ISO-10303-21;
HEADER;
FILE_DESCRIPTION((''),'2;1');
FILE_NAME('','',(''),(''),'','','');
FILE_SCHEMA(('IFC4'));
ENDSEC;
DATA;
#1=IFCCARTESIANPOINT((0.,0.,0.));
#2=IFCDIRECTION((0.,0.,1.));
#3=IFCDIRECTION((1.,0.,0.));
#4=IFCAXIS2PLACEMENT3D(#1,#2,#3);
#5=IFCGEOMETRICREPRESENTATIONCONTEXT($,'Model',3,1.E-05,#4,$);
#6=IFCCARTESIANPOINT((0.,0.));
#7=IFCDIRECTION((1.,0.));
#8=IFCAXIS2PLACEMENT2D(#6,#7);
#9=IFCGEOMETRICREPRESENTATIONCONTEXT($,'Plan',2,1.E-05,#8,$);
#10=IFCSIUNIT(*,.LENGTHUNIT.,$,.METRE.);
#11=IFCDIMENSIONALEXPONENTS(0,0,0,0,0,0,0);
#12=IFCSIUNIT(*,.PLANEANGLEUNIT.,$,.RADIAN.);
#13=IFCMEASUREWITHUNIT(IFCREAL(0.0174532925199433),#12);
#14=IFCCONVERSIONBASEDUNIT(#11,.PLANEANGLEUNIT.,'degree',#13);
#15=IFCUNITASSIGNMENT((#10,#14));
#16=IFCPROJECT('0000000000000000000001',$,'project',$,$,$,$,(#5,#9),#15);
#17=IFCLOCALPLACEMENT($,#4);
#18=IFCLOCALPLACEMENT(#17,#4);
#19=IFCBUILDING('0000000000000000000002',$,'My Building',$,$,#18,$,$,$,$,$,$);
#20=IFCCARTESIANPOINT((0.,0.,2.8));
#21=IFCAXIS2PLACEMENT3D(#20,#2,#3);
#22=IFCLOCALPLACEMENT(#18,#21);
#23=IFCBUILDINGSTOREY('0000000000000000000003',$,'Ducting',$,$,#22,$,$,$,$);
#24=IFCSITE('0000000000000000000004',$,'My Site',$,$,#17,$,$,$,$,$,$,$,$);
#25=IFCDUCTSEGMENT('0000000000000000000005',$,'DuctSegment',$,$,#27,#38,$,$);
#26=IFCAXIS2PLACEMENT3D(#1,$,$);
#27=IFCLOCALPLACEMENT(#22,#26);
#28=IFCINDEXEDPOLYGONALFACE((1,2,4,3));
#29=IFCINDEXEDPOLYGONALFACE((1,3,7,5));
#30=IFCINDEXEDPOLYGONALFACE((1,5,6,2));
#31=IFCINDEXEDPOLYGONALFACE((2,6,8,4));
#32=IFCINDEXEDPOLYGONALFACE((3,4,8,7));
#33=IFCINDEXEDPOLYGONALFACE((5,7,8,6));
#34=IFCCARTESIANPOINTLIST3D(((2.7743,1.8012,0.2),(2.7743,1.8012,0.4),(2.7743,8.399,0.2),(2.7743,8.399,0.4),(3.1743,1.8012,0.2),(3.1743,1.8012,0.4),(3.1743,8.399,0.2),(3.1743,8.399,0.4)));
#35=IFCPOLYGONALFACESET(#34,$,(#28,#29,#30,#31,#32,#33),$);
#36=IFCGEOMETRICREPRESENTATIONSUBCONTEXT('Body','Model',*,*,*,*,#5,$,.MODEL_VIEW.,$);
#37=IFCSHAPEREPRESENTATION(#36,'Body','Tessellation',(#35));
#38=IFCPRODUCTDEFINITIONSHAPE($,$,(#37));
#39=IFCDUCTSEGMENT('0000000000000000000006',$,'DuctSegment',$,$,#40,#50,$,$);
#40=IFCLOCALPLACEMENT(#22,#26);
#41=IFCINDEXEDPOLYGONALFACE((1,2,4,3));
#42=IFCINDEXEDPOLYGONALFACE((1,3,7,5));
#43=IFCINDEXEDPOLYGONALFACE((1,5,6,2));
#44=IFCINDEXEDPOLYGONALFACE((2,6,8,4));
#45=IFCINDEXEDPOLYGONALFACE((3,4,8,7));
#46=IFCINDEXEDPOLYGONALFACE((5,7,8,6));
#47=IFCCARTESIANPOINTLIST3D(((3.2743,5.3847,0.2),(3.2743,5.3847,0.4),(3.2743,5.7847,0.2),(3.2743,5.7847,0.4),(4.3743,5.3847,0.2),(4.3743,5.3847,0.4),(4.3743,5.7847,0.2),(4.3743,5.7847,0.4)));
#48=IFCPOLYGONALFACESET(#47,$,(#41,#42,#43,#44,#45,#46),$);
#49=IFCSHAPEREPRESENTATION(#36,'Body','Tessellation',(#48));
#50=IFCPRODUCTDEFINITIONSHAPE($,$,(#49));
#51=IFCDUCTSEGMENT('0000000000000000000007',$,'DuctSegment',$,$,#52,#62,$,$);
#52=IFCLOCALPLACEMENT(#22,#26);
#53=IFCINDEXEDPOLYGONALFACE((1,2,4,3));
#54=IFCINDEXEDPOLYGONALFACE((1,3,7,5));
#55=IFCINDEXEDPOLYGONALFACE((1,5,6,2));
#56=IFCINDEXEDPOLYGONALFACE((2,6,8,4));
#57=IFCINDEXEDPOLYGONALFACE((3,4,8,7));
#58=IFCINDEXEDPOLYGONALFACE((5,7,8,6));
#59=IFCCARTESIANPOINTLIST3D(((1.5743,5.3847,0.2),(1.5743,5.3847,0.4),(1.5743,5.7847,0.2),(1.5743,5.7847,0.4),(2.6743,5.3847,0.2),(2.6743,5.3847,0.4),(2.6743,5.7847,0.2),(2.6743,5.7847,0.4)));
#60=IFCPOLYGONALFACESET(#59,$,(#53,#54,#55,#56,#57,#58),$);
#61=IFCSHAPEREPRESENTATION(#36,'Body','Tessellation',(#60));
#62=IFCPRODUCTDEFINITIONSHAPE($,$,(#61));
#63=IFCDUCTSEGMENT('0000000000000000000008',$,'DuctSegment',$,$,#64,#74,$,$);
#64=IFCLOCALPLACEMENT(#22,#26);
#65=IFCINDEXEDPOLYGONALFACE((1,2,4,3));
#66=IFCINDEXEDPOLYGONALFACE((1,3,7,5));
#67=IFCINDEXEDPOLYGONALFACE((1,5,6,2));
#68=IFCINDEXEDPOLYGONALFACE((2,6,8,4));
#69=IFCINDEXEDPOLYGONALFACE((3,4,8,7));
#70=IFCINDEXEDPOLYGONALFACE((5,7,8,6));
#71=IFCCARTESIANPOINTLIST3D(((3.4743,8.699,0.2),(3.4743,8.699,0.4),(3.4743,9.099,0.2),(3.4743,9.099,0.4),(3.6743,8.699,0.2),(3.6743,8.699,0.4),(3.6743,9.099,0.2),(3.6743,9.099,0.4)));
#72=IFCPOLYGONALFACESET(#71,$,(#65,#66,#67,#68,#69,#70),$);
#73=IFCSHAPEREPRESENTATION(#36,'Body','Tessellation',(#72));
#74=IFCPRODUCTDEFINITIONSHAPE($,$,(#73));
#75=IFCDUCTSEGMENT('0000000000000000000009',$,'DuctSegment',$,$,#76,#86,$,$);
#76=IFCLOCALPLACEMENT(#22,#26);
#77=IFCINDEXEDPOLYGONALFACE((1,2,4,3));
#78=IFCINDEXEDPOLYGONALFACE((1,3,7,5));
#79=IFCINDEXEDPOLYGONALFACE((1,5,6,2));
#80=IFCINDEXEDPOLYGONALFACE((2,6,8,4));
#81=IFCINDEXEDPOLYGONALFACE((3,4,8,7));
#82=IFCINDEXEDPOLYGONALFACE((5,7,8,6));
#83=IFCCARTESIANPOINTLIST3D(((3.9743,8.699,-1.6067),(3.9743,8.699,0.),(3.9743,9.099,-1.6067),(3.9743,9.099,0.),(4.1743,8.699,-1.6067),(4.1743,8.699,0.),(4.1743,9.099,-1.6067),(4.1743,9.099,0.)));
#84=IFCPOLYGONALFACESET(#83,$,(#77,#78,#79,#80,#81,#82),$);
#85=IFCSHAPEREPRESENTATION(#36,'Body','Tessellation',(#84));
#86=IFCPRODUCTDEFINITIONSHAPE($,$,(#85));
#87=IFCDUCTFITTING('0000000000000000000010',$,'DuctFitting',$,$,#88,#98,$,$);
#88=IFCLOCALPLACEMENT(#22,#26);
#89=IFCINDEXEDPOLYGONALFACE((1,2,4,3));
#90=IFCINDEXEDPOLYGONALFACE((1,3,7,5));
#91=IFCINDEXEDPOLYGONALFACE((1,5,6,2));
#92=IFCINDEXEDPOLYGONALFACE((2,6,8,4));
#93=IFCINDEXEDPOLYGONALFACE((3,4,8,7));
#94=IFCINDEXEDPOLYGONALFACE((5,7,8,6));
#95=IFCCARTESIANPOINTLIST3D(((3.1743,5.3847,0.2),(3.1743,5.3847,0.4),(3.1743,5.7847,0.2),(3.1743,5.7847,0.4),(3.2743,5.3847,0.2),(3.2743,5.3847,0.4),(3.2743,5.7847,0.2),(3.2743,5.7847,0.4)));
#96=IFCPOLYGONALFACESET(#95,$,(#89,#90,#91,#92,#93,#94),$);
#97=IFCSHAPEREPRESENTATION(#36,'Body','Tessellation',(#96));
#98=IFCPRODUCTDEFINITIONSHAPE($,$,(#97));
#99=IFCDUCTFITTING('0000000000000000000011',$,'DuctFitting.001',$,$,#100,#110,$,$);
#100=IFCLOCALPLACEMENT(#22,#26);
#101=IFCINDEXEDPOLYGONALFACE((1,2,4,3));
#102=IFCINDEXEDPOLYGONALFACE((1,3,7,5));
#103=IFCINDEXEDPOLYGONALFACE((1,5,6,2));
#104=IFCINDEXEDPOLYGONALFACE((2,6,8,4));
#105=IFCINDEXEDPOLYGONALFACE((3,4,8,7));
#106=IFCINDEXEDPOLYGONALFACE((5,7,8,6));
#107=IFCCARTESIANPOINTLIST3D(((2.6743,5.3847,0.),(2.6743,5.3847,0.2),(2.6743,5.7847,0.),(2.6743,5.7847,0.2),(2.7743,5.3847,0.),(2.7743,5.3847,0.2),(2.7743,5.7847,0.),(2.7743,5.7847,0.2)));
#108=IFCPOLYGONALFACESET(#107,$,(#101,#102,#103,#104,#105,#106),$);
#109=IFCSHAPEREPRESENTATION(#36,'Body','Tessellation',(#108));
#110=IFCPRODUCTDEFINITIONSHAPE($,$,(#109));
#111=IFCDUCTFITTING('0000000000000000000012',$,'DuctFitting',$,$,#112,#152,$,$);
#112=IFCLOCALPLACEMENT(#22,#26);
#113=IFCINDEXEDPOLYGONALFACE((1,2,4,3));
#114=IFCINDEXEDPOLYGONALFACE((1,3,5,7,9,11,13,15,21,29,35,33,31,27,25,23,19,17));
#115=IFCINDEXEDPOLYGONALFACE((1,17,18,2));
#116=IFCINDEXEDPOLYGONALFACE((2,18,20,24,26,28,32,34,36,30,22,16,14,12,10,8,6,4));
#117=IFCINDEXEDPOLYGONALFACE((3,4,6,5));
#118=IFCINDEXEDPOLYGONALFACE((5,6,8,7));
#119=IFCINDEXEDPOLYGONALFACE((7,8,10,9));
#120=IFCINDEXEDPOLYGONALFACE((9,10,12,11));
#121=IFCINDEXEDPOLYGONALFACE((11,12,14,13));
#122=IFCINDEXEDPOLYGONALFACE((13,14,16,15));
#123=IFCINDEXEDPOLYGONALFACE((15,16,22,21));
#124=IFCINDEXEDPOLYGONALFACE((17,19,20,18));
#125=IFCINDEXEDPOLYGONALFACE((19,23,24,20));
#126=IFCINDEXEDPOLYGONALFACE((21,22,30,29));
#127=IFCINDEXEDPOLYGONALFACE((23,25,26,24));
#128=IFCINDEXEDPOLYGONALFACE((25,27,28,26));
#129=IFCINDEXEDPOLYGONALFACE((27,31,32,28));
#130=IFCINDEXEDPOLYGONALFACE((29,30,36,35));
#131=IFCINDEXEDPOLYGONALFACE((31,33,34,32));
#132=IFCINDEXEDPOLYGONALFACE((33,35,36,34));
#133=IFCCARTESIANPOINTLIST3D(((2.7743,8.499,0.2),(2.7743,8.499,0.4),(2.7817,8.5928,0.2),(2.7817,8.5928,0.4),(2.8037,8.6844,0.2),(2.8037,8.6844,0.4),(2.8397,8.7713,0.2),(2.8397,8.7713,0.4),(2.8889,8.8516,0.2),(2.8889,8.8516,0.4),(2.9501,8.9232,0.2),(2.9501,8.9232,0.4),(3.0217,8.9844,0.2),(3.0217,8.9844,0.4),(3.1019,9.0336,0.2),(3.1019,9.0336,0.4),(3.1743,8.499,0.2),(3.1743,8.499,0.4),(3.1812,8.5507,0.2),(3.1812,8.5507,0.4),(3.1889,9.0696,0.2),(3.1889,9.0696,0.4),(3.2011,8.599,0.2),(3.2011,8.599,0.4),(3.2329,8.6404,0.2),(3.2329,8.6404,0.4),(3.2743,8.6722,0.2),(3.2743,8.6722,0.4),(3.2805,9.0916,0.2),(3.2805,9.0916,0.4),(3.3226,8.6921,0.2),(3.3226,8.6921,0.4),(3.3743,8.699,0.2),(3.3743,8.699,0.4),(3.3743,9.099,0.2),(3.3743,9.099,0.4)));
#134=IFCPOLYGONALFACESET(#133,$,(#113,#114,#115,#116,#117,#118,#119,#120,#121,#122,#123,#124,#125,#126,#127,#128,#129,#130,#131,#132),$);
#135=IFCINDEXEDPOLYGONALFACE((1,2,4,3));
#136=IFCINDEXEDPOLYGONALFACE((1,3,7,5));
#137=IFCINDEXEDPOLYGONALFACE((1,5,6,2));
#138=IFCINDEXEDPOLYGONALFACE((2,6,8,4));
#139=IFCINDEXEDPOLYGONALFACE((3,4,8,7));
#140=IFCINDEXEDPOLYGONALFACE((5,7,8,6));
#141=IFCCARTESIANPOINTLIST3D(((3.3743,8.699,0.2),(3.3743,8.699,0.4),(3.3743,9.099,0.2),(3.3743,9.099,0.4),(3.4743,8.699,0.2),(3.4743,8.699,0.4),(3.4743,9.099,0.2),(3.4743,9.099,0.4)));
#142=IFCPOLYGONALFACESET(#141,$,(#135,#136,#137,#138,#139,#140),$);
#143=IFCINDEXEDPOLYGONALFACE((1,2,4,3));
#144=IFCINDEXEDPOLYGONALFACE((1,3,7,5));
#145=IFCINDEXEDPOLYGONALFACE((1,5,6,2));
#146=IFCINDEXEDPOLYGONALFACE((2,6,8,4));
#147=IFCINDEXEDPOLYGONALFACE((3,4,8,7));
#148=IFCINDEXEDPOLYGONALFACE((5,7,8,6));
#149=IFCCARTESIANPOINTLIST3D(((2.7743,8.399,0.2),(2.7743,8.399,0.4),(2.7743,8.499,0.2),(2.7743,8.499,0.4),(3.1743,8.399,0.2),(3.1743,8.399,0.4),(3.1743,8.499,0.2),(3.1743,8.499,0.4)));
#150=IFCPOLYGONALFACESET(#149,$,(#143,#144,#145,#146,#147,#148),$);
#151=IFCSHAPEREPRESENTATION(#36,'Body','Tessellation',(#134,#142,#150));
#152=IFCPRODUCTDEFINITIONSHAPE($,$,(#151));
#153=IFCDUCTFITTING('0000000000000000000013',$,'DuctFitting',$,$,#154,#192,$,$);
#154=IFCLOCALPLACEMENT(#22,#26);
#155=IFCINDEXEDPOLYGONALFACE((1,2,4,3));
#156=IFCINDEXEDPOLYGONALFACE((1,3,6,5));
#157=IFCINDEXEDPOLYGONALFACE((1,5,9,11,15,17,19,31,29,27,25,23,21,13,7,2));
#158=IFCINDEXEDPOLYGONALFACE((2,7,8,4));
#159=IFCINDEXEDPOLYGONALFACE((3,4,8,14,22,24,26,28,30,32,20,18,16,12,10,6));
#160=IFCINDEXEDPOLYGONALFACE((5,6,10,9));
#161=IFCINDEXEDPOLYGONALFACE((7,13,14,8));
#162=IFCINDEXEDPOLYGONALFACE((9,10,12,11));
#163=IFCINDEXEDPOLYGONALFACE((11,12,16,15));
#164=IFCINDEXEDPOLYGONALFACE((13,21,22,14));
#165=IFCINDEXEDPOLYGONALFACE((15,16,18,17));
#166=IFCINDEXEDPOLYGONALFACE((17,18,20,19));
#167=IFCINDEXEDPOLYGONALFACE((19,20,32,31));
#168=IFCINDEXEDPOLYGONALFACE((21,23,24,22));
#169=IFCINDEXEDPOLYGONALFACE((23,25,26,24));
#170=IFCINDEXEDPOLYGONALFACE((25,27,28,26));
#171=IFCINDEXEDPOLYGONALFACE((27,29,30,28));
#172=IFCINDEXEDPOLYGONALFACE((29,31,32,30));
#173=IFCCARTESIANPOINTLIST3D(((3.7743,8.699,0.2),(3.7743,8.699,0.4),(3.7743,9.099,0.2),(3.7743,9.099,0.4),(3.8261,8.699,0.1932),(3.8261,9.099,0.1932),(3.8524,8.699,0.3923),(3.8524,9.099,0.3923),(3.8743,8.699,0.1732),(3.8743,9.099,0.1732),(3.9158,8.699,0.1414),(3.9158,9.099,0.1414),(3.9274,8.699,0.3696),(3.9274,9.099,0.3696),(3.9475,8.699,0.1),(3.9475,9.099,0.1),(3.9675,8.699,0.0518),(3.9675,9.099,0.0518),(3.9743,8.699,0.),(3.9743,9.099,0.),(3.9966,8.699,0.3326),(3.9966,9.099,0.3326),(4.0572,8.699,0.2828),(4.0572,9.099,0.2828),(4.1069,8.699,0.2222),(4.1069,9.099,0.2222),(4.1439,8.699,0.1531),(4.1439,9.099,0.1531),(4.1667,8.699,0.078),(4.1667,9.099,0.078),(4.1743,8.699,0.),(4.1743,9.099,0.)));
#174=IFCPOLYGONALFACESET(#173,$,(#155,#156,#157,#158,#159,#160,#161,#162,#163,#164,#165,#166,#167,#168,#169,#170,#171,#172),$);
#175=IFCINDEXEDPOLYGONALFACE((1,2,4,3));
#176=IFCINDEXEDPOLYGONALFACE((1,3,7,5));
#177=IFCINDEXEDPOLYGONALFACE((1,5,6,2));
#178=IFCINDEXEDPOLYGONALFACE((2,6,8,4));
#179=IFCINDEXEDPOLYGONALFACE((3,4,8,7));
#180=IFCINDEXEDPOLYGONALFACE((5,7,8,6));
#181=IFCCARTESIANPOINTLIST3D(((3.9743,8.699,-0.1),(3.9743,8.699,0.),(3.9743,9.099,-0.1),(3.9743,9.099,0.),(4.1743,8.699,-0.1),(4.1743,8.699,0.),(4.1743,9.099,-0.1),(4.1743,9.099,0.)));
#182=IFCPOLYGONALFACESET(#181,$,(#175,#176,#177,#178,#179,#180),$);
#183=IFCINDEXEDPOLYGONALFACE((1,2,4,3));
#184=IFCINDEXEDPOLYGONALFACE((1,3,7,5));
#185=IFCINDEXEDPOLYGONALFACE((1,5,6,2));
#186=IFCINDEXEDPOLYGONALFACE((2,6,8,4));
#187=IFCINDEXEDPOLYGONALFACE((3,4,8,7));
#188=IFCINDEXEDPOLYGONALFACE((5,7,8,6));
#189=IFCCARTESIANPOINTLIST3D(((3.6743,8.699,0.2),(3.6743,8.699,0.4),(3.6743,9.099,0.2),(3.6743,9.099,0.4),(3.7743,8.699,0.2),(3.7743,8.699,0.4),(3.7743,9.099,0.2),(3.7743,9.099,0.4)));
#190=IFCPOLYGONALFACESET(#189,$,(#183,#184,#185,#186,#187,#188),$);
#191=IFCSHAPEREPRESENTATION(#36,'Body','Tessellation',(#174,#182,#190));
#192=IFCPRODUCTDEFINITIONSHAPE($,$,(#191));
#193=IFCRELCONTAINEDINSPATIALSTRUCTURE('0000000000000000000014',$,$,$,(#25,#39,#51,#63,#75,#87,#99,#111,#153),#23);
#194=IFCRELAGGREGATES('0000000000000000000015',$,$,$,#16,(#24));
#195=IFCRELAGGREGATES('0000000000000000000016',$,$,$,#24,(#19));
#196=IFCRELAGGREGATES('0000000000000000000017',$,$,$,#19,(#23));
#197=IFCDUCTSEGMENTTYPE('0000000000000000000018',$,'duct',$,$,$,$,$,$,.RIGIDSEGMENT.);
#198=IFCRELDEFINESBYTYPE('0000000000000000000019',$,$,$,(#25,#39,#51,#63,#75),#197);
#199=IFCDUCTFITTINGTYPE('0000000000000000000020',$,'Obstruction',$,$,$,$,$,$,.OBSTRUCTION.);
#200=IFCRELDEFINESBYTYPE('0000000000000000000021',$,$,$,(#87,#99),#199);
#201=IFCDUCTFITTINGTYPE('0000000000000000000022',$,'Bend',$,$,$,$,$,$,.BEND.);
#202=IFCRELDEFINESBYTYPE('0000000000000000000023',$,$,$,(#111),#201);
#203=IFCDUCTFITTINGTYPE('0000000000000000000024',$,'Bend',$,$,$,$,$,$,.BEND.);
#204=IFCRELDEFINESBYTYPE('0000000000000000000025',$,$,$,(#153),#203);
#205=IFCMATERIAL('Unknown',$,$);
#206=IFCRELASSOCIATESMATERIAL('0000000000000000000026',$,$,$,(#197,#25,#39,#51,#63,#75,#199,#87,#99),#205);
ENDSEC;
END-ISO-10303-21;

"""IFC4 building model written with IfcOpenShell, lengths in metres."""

from ifc_helpers import new_model, entity, si_unit, converted_unit, frame, origin_with_axes, origin_2d_with_axis, place, context, subcontext, project, spatial, line, arc, indexed_curve, rectangle, outline, extrude, source, transform, mapped, material, material_profile, profile_set, profile_usage, type_object, type_shapes, element, save


model = new_model("IFC4")

# Units and contexts
model_context = context("Model", 3, precision=1e-05, world=origin_with_axes())
plan_context = context("Plan", 2, precision=1e-05, world=origin_2d_with_axis())
body_context = subcontext(model_context, "Body", "Model", "MODEL_VIEW")
ifc_project = project(units=[si_unit("LENGTHUNIT", "METRE"), converted_unit("PLANEANGLEUNIT", "degree", entity("IfcReal", 0.0174532925199433), si_unit("PLANEANGLEUNIT", "RADIAN"), dimensions=[0, 0, 0, 0, 0, 0, 0])], contexts=[model_context, plan_context])

# Site, building, storey
site_placement = place(None, origin_with_axes())
site = spatial("IfcSite", under=ifc_project, at=site_placement, Name="My Site")
building_placement = place(site_placement, origin_with_axes())
building = spatial("IfcBuilding", under=site, at=building_placement, Name="My Building")
storey_placement = place(building_placement, frame((0.0, 0.0, 2.8), z_axis=(0.0, 0.0, 1.0), x_axis=(1.0, 0.0, 0.0)))
storey = spatial("IfcBuildingStorey", under=building, at=storey_placement, Name="Ducting")

# Duct segments
ifc_material = material(Name="Unknown")
ifc_material_profile_1 = material_profile(ifc_material, rectangle(XDim=0.4, YDim=0.2))
ifc_profile_set_1 = profile_set([ifc_material_profile_1])
ifc_profile_usage_1 = profile_usage(ifc_profile_set_1, cardinal=5)
duct_segment_type = type_object("IfcDuctSegmentType", Name="duct", PredefinedType="RIGIDSEGMENT", material=ifc_profile_set_1)
duct_segment_1_placement = place(storey_placement, frame((2.9743, 8.399, 0.3), z_axis=(0.0, -1.0, 0.0), x_axis=(1.0, 0.0, 0.0)))
element("IfcDuctSegment", 1, at=duct_segment_1_placement, inside=storey, type_object=duct_segment_type, material=ifc_profile_usage_1, Name="DuctSegment", context=body_context, shape_type="SweptSolid", body=[
    extrude(rectangle(XDim=0.4, YDim=0.2), origin_with_axes(), (0.0, 0.0, 1.0), 6.5978),
])
ifc_profile_usage_2 = profile_usage(ifc_profile_set_1, cardinal=5)
duct_segment_2_placement = place(storey_placement, frame((3.2743, 5.5847, 0.3), z_axis=(1.0, 0.0, 0.0), x_axis=(0.0, 1.0, 0.0)))
element("IfcDuctSegment", 2, at=duct_segment_2_placement, inside=storey, type_object=duct_segment_type, material=ifc_profile_usage_2, Name="DuctSegment", context=body_context, shape_type="SweptSolid", body=[
    extrude(rectangle(XDim=0.4, YDim=0.2), origin_with_axes(), (0.0, 0.0, 1.0), 1.1),
])
ifc_profile_usage_3 = profile_usage(ifc_profile_set_1, cardinal=5)
duct_segment_3_placement = place(storey_placement, frame((1.5743, 5.5847, 0.3), z_axis=(1.0, 0.0, 0.0), x_axis=(0.0, 1.0, 0.0)))
element("IfcDuctSegment", 3, at=duct_segment_3_placement, inside=storey, type_object=duct_segment_type, material=ifc_profile_usage_3, Name="DuctSegment", context=body_context, shape_type="SweptSolid", body=[
    extrude(rectangle(XDim=0.4, YDim=0.2), origin_with_axes(), (0.0, 0.0, 1.0), 1.1),
])
ifc_profile_usage_4 = profile_usage(ifc_profile_set_1, cardinal=5)
duct_segment_4_placement = place(storey_placement, frame((3.4743, 8.899, 0.3), z_axis=(1.0, 0.0, 0.0), x_axis=(0.0, 1.0, 0.0)))
element("IfcDuctSegment", 4, at=duct_segment_4_placement, inside=storey, type_object=duct_segment_type, material=ifc_profile_usage_4, Name="DuctSegment", context=body_context, shape_type="SweptSolid", body=[
    extrude(rectangle(XDim=0.4, YDim=0.2), origin_with_axes(), (0.0, 0.0, 1.0), 0.2),
])
ifc_profile_usage_5 = profile_usage(ifc_profile_set_1, cardinal=5)
duct_segment_5_placement = place(storey_placement, frame((4.0743, 8.899, 0.0), z_axis=(0.0, 0.0, -1.0), x_axis=(0.0, -1.0, 0.0)))
element("IfcDuctSegment", 5, at=duct_segment_5_placement, inside=storey, type_object=duct_segment_type, material=ifc_profile_usage_5, Name="DuctSegment", context=body_context, shape_type="SweptSolid", body=[
    extrude(rectangle(XDim=0.4, YDim=0.2), origin_with_axes(), (0.0, 0.0, 1.0), 1.6067),
])

# Duct fittings
ifc_material_profile_2 = material_profile(ifc_material, rectangle(XDim=0.4, YDim=0.2))
ifc_profile_set_2 = profile_set([ifc_material_profile_2])
ifc_profile_usage_6 = profile_usage(ifc_profile_set_2, cardinal=5)
duct_fitting_type_1 = type_object("IfcDuctFittingType", Name="Obstruction", PredefinedType="OBSTRUCTION", material=ifc_profile_set_2)
duct_fitting_1_placement = place(storey_placement, frame((3.1743, 5.5847, 0.3), z_axis=(1.0, 0.0, 0.0), x_axis=(0.0, 1.0, 0.0)))
element("IfcDuctFitting", 6, at=duct_fitting_1_placement, inside=storey, type_object=duct_fitting_type_1, material=ifc_profile_usage_6, Name="DuctFitting", context=body_context, shape_type="SweptSolid", body=[
    extrude(rectangle(XDim=0.4, YDim=0.2), origin_with_axes(), (0.0, 0.0, 1.0), 0.1),
])
ifc_profile_usage_7 = profile_usage(ifc_profile_set_2, cardinal=5)
duct_fitting_2_placement = place(storey_placement, frame((2.6743, 5.5847, 0.1), z_axis=(1.0, 0.0, 0.0), x_axis=(0.0, 1.0, 0.0)))
element("IfcDuctFitting", 7, at=duct_fitting_2_placement, inside=storey, type_object=duct_fitting_type_1, material=ifc_profile_usage_7, Name="DuctFitting.001", context=body_context, shape_type="SweptSolid", body=[
    extrude(rectangle(XDim=0.4, YDim=0.2), origin_with_axes(), (0.0, 0.0, 1.0), 0.1),
])
duct_fitting_type_2 = type_object("IfcDuctFittingType", Name="Bend", PredefinedType="BEND")
shared_shape_1 = source(origin_with_axes(), body_context, "Body", "SweptSolid", [
    extrude(outline(indexed_curve([(-0.2, 0.0), (-0.2586, -0.1414), (-0.4, -0.2), (-0.4, -0.6), (0.0243, -0.4243), (0.2, 0.0)], segments=[arc(1, 2, 3), line(3, 4), arc(4, 5, 6), line(6, 1)])), frame((0.0, -0.1, -0.1), z_axis=(0.0, -1.0, 0.0), x_axis=(1.0, 0.0, 0.0)), (0.0, 0.0, -1.0), 0.2),
    extrude(rectangle(XDim=0.4, YDim=0.2), origin_with_axes(), (0.0, 0.0, -1.0), 0.1),
    extrude(rectangle(XDim=0.4, YDim=0.2), frame((-0.4, 0.0, -0.5), z_axis=(-1.0, 0.0, 0.0), x_axis=(0.0, 0.0, -1.0)), (0.0, 0.0, 1.0), 0.1),
])
type_shapes(duct_fitting_type_2, [shared_shape_1])
duct_fitting_3_placement = place(storey_placement, frame((3.4743, 8.899, 0.3), z_axis=(1.0, 0.0, 0.0), x_axis=(0.0, 1.0, 0.0)))
element("IfcDuctFitting", 8, at=duct_fitting_3_placement, inside=storey, type_object=duct_fitting_type_2, Name="DuctFitting", context=body_context, shape_type="MappedRepresentation", body=[
    mapped(shared_shape_1, transform((0.0, 0.0, 0.0), x_axis=(1.0, 0.0, 0.0), y_axis=(0.0, 1.0, 0.0), z_axis=(0.0, 0.0, 1.0), scale=1.0)),
])
duct_fitting_type_3 = type_object("IfcDuctFittingType", Name="Bend", PredefinedType="BEND")
shared_shape_2 = source(origin_with_axes(), body_context, "Body", "SweptSolid", [
    extrude(outline(indexed_curve([(-0.1, 0.0), (-0.1586, -0.1414), (-0.3, -0.2), (-0.3, -0.4), (-0.0172, -0.2828), (0.1, 0.0)], segments=[arc(1, 2, 3), line(3, 4), arc(4, 5, 6), line(6, 1)])), frame((-0.2, 0.0, -0.1), z_axis=(1.0, 0.0, 0.0), x_axis=(0.0, 1.0, 0.0)), (0.0, 0.0, 1.0), 0.4),
    extrude(rectangle(XDim=0.4, YDim=0.2), origin_with_axes(), (0.0, 0.0, -1.0), 0.1),
    extrude(rectangle(XDim=0.4, YDim=0.2), frame((0.0, -0.3, -0.4), z_axis=(0.0, -1.0, 0.0), x_axis=(1.0, 0.0, 0.0)), (0.0, 0.0, 1.0), 0.1),
])
type_shapes(duct_fitting_type_3, [shared_shape_2])
duct_fitting_4_placement = place(storey_placement, frame((4.0743, 8.899, -0.1), z_axis=(0.0, 0.0, -1.0), x_axis=(0.0, 1.0, 0.0)))
element("IfcDuctFitting", 9, at=duct_fitting_4_placement, inside=storey, type_object=duct_fitting_type_3, Name="DuctFitting", context=body_context, shape_type="MappedRepresentation", body=[
    mapped(shared_shape_2, transform((0.0, 0.0, 0.0), x_axis=(1.0, 0.0, 0.0), y_axis=(0.0, 1.0, 0.0), z_axis=(0.0, 0.0, 1.0), scale=1.0)),
])

save(model, "model.ifc")
